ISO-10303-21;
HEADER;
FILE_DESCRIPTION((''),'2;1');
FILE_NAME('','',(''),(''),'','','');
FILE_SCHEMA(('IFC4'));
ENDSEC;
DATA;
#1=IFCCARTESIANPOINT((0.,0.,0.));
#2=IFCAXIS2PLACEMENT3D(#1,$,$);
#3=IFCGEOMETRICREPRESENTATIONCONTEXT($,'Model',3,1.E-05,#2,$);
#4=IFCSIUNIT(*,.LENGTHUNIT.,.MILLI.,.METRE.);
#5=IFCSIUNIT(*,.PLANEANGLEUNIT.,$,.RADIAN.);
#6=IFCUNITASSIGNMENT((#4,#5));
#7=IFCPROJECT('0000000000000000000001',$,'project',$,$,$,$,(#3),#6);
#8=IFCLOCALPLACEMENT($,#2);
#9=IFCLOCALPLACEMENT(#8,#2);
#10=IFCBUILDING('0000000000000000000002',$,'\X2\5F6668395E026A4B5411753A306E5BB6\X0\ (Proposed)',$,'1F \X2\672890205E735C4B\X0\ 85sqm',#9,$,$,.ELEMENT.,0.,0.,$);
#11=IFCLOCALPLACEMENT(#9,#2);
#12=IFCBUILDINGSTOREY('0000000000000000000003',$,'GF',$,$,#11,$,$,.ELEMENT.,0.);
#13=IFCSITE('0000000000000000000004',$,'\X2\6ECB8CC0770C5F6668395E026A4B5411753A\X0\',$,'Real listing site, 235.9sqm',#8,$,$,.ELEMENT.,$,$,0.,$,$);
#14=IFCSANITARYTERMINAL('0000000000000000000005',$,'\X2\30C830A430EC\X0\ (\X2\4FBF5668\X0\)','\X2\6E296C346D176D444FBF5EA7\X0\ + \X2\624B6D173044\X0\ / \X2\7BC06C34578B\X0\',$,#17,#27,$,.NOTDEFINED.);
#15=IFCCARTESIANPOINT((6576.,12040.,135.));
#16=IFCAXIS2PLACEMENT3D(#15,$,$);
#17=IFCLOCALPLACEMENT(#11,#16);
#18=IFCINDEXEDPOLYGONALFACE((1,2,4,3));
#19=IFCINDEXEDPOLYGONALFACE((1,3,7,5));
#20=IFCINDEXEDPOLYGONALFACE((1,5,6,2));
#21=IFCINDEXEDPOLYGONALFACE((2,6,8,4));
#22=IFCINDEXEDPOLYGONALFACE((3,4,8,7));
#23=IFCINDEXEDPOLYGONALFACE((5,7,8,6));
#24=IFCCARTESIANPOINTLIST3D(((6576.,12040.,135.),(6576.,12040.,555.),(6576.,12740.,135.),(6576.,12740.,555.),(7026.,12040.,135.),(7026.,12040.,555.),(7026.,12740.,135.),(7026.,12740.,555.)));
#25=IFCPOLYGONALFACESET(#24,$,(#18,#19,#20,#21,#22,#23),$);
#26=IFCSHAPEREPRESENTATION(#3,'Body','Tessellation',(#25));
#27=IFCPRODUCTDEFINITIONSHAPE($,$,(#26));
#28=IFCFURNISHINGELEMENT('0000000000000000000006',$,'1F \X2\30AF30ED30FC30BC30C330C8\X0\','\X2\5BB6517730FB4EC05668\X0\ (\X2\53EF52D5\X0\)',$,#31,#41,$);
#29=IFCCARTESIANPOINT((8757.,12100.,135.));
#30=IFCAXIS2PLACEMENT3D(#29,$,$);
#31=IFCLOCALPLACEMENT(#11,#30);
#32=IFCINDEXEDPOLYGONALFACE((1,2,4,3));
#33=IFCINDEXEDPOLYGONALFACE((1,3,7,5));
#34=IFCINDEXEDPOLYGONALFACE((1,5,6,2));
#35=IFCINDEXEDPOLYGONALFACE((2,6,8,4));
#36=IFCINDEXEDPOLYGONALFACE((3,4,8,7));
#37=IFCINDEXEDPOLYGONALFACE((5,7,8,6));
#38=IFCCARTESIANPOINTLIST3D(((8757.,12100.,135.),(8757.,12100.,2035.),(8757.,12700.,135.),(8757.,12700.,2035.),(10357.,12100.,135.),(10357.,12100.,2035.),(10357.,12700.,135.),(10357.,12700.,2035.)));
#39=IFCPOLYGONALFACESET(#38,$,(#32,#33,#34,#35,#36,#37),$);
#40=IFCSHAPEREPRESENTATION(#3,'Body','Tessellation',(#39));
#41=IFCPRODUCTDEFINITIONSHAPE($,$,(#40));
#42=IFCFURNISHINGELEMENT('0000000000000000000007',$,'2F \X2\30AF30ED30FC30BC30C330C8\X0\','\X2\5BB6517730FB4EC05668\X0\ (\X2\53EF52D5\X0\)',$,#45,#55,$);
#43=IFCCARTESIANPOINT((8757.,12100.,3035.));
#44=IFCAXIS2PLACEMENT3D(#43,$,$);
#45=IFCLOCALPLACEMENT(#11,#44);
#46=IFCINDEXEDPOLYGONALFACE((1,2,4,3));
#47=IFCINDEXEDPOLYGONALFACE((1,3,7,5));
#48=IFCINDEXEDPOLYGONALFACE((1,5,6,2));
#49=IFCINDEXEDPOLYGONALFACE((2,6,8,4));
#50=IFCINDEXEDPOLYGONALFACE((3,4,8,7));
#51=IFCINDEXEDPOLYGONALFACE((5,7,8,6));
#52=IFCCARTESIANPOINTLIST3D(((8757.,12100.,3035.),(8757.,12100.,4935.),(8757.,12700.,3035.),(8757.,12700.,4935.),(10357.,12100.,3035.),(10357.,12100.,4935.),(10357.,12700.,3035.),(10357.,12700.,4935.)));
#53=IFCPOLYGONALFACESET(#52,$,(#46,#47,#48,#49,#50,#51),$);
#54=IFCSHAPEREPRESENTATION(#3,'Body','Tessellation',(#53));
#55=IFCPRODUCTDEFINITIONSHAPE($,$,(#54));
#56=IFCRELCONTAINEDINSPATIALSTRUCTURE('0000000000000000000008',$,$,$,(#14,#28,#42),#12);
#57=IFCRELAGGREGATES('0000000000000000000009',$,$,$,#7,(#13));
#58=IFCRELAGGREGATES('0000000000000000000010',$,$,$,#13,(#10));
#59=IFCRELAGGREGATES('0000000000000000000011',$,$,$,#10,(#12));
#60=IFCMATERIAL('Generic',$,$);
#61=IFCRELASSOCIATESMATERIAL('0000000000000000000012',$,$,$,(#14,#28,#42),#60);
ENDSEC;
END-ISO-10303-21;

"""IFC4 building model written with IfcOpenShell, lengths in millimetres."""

from ifc_helpers import new_model, si_unit, frame, frame_2d, origin, place, context, project, spatial, rectangle, extrude, material, element, save


model = new_model("IFC4")

# Units and contexts
model_context = context("Model", 3, precision=1e-05, world=origin())
ifc_project = project(units=[si_unit("LENGTHUNIT", "METRE", prefix="MILLI"), si_unit("PLANEANGLEUNIT", "RADIAN")], contexts=[model_context])

# Site, building, storey
site_placement = place(None, origin())
site = spatial("IfcSite", under=ifc_project, at=site_placement, Name="滋賀県彦根市橋向町", ObjectType="Real listing site, 235.9sqm", CompositionType="ELEMENT", RefElevation=0.0)
building_placement = place(site_placement, origin())
building = spatial("IfcBuilding", under=site, at=building_placement, Name="彦根市橋向町の家 (Proposed)", ObjectType="1F 木造平屋 85sqm", CompositionType="ELEMENT", ElevationOfRefHeight=0.0, ElevationOfTerrain=0.0)
storey_placement = place(building_placement, origin())
storey = spatial("IfcBuildingStorey", under=building, at=storey_placement, Name="GF", CompositionType="ELEMENT", Elevation=0.0)

# Sanitary terminal
ifc_material_1 = material(Name="Generic")
sanitary_terminal_1_placement = place(storey_placement, frame((6576.0, 12040.0, 135.0)))
element("IfcSanitaryTerminal", 1, at=sanitary_terminal_1_placement, inside=storey, material=ifc_material_1, Name="トイレ (便器)", Description="温水洗浄便座 + 手洗い / 節水型", PredefinedType="NOTDEFINED", context=model_context, shape_type="SweptSolid", body=[
    extrude(rectangle(XDim=450.0, YDim=700.0, at=frame_2d((225.0, 350.0))), frame((6576.0, 12040.0, 135.0)), (0.0, 0.0, 1.0), 420.0),
])

# Furnishing elements
furnishing_1_placement = place(storey_placement, frame((8757.0, 12100.0, 135.0)))
element("IfcFurnishingElement", 2, at=furnishing_1_placement, inside=storey, material=ifc_material_1, Name="1F クローゼット", Description="家具・什器 (可動)", context=model_context, shape_type="SweptSolid", body=[
    extrude(rectangle(XDim=1600.0, YDim=600.0, at=frame_2d((800.0, 300.0))), frame((8757.0, 12100.0, 135.0)), (0.0, 0.0, 1.0), 1900.0),
])
furnishing_2_placement = place(storey_placement, frame((8757.0, 12100.0, 3035.0)))
element("IfcFurnishingElement", 3, at=furnishing_2_placement, inside=storey, material=ifc_material_1, Name="2F クローゼット", Description="家具・什器 (可動)", context=model_context, shape_type="SweptSolid", body=[
    extrude(rectangle(XDim=1600.0, YDim=600.0, at=frame_2d((800.0, 300.0))), frame((8757.0, 12100.0, 3035.0)), (0.0, 0.0, 1.0), 1900.0),
])

save(model, "model.ifc")
